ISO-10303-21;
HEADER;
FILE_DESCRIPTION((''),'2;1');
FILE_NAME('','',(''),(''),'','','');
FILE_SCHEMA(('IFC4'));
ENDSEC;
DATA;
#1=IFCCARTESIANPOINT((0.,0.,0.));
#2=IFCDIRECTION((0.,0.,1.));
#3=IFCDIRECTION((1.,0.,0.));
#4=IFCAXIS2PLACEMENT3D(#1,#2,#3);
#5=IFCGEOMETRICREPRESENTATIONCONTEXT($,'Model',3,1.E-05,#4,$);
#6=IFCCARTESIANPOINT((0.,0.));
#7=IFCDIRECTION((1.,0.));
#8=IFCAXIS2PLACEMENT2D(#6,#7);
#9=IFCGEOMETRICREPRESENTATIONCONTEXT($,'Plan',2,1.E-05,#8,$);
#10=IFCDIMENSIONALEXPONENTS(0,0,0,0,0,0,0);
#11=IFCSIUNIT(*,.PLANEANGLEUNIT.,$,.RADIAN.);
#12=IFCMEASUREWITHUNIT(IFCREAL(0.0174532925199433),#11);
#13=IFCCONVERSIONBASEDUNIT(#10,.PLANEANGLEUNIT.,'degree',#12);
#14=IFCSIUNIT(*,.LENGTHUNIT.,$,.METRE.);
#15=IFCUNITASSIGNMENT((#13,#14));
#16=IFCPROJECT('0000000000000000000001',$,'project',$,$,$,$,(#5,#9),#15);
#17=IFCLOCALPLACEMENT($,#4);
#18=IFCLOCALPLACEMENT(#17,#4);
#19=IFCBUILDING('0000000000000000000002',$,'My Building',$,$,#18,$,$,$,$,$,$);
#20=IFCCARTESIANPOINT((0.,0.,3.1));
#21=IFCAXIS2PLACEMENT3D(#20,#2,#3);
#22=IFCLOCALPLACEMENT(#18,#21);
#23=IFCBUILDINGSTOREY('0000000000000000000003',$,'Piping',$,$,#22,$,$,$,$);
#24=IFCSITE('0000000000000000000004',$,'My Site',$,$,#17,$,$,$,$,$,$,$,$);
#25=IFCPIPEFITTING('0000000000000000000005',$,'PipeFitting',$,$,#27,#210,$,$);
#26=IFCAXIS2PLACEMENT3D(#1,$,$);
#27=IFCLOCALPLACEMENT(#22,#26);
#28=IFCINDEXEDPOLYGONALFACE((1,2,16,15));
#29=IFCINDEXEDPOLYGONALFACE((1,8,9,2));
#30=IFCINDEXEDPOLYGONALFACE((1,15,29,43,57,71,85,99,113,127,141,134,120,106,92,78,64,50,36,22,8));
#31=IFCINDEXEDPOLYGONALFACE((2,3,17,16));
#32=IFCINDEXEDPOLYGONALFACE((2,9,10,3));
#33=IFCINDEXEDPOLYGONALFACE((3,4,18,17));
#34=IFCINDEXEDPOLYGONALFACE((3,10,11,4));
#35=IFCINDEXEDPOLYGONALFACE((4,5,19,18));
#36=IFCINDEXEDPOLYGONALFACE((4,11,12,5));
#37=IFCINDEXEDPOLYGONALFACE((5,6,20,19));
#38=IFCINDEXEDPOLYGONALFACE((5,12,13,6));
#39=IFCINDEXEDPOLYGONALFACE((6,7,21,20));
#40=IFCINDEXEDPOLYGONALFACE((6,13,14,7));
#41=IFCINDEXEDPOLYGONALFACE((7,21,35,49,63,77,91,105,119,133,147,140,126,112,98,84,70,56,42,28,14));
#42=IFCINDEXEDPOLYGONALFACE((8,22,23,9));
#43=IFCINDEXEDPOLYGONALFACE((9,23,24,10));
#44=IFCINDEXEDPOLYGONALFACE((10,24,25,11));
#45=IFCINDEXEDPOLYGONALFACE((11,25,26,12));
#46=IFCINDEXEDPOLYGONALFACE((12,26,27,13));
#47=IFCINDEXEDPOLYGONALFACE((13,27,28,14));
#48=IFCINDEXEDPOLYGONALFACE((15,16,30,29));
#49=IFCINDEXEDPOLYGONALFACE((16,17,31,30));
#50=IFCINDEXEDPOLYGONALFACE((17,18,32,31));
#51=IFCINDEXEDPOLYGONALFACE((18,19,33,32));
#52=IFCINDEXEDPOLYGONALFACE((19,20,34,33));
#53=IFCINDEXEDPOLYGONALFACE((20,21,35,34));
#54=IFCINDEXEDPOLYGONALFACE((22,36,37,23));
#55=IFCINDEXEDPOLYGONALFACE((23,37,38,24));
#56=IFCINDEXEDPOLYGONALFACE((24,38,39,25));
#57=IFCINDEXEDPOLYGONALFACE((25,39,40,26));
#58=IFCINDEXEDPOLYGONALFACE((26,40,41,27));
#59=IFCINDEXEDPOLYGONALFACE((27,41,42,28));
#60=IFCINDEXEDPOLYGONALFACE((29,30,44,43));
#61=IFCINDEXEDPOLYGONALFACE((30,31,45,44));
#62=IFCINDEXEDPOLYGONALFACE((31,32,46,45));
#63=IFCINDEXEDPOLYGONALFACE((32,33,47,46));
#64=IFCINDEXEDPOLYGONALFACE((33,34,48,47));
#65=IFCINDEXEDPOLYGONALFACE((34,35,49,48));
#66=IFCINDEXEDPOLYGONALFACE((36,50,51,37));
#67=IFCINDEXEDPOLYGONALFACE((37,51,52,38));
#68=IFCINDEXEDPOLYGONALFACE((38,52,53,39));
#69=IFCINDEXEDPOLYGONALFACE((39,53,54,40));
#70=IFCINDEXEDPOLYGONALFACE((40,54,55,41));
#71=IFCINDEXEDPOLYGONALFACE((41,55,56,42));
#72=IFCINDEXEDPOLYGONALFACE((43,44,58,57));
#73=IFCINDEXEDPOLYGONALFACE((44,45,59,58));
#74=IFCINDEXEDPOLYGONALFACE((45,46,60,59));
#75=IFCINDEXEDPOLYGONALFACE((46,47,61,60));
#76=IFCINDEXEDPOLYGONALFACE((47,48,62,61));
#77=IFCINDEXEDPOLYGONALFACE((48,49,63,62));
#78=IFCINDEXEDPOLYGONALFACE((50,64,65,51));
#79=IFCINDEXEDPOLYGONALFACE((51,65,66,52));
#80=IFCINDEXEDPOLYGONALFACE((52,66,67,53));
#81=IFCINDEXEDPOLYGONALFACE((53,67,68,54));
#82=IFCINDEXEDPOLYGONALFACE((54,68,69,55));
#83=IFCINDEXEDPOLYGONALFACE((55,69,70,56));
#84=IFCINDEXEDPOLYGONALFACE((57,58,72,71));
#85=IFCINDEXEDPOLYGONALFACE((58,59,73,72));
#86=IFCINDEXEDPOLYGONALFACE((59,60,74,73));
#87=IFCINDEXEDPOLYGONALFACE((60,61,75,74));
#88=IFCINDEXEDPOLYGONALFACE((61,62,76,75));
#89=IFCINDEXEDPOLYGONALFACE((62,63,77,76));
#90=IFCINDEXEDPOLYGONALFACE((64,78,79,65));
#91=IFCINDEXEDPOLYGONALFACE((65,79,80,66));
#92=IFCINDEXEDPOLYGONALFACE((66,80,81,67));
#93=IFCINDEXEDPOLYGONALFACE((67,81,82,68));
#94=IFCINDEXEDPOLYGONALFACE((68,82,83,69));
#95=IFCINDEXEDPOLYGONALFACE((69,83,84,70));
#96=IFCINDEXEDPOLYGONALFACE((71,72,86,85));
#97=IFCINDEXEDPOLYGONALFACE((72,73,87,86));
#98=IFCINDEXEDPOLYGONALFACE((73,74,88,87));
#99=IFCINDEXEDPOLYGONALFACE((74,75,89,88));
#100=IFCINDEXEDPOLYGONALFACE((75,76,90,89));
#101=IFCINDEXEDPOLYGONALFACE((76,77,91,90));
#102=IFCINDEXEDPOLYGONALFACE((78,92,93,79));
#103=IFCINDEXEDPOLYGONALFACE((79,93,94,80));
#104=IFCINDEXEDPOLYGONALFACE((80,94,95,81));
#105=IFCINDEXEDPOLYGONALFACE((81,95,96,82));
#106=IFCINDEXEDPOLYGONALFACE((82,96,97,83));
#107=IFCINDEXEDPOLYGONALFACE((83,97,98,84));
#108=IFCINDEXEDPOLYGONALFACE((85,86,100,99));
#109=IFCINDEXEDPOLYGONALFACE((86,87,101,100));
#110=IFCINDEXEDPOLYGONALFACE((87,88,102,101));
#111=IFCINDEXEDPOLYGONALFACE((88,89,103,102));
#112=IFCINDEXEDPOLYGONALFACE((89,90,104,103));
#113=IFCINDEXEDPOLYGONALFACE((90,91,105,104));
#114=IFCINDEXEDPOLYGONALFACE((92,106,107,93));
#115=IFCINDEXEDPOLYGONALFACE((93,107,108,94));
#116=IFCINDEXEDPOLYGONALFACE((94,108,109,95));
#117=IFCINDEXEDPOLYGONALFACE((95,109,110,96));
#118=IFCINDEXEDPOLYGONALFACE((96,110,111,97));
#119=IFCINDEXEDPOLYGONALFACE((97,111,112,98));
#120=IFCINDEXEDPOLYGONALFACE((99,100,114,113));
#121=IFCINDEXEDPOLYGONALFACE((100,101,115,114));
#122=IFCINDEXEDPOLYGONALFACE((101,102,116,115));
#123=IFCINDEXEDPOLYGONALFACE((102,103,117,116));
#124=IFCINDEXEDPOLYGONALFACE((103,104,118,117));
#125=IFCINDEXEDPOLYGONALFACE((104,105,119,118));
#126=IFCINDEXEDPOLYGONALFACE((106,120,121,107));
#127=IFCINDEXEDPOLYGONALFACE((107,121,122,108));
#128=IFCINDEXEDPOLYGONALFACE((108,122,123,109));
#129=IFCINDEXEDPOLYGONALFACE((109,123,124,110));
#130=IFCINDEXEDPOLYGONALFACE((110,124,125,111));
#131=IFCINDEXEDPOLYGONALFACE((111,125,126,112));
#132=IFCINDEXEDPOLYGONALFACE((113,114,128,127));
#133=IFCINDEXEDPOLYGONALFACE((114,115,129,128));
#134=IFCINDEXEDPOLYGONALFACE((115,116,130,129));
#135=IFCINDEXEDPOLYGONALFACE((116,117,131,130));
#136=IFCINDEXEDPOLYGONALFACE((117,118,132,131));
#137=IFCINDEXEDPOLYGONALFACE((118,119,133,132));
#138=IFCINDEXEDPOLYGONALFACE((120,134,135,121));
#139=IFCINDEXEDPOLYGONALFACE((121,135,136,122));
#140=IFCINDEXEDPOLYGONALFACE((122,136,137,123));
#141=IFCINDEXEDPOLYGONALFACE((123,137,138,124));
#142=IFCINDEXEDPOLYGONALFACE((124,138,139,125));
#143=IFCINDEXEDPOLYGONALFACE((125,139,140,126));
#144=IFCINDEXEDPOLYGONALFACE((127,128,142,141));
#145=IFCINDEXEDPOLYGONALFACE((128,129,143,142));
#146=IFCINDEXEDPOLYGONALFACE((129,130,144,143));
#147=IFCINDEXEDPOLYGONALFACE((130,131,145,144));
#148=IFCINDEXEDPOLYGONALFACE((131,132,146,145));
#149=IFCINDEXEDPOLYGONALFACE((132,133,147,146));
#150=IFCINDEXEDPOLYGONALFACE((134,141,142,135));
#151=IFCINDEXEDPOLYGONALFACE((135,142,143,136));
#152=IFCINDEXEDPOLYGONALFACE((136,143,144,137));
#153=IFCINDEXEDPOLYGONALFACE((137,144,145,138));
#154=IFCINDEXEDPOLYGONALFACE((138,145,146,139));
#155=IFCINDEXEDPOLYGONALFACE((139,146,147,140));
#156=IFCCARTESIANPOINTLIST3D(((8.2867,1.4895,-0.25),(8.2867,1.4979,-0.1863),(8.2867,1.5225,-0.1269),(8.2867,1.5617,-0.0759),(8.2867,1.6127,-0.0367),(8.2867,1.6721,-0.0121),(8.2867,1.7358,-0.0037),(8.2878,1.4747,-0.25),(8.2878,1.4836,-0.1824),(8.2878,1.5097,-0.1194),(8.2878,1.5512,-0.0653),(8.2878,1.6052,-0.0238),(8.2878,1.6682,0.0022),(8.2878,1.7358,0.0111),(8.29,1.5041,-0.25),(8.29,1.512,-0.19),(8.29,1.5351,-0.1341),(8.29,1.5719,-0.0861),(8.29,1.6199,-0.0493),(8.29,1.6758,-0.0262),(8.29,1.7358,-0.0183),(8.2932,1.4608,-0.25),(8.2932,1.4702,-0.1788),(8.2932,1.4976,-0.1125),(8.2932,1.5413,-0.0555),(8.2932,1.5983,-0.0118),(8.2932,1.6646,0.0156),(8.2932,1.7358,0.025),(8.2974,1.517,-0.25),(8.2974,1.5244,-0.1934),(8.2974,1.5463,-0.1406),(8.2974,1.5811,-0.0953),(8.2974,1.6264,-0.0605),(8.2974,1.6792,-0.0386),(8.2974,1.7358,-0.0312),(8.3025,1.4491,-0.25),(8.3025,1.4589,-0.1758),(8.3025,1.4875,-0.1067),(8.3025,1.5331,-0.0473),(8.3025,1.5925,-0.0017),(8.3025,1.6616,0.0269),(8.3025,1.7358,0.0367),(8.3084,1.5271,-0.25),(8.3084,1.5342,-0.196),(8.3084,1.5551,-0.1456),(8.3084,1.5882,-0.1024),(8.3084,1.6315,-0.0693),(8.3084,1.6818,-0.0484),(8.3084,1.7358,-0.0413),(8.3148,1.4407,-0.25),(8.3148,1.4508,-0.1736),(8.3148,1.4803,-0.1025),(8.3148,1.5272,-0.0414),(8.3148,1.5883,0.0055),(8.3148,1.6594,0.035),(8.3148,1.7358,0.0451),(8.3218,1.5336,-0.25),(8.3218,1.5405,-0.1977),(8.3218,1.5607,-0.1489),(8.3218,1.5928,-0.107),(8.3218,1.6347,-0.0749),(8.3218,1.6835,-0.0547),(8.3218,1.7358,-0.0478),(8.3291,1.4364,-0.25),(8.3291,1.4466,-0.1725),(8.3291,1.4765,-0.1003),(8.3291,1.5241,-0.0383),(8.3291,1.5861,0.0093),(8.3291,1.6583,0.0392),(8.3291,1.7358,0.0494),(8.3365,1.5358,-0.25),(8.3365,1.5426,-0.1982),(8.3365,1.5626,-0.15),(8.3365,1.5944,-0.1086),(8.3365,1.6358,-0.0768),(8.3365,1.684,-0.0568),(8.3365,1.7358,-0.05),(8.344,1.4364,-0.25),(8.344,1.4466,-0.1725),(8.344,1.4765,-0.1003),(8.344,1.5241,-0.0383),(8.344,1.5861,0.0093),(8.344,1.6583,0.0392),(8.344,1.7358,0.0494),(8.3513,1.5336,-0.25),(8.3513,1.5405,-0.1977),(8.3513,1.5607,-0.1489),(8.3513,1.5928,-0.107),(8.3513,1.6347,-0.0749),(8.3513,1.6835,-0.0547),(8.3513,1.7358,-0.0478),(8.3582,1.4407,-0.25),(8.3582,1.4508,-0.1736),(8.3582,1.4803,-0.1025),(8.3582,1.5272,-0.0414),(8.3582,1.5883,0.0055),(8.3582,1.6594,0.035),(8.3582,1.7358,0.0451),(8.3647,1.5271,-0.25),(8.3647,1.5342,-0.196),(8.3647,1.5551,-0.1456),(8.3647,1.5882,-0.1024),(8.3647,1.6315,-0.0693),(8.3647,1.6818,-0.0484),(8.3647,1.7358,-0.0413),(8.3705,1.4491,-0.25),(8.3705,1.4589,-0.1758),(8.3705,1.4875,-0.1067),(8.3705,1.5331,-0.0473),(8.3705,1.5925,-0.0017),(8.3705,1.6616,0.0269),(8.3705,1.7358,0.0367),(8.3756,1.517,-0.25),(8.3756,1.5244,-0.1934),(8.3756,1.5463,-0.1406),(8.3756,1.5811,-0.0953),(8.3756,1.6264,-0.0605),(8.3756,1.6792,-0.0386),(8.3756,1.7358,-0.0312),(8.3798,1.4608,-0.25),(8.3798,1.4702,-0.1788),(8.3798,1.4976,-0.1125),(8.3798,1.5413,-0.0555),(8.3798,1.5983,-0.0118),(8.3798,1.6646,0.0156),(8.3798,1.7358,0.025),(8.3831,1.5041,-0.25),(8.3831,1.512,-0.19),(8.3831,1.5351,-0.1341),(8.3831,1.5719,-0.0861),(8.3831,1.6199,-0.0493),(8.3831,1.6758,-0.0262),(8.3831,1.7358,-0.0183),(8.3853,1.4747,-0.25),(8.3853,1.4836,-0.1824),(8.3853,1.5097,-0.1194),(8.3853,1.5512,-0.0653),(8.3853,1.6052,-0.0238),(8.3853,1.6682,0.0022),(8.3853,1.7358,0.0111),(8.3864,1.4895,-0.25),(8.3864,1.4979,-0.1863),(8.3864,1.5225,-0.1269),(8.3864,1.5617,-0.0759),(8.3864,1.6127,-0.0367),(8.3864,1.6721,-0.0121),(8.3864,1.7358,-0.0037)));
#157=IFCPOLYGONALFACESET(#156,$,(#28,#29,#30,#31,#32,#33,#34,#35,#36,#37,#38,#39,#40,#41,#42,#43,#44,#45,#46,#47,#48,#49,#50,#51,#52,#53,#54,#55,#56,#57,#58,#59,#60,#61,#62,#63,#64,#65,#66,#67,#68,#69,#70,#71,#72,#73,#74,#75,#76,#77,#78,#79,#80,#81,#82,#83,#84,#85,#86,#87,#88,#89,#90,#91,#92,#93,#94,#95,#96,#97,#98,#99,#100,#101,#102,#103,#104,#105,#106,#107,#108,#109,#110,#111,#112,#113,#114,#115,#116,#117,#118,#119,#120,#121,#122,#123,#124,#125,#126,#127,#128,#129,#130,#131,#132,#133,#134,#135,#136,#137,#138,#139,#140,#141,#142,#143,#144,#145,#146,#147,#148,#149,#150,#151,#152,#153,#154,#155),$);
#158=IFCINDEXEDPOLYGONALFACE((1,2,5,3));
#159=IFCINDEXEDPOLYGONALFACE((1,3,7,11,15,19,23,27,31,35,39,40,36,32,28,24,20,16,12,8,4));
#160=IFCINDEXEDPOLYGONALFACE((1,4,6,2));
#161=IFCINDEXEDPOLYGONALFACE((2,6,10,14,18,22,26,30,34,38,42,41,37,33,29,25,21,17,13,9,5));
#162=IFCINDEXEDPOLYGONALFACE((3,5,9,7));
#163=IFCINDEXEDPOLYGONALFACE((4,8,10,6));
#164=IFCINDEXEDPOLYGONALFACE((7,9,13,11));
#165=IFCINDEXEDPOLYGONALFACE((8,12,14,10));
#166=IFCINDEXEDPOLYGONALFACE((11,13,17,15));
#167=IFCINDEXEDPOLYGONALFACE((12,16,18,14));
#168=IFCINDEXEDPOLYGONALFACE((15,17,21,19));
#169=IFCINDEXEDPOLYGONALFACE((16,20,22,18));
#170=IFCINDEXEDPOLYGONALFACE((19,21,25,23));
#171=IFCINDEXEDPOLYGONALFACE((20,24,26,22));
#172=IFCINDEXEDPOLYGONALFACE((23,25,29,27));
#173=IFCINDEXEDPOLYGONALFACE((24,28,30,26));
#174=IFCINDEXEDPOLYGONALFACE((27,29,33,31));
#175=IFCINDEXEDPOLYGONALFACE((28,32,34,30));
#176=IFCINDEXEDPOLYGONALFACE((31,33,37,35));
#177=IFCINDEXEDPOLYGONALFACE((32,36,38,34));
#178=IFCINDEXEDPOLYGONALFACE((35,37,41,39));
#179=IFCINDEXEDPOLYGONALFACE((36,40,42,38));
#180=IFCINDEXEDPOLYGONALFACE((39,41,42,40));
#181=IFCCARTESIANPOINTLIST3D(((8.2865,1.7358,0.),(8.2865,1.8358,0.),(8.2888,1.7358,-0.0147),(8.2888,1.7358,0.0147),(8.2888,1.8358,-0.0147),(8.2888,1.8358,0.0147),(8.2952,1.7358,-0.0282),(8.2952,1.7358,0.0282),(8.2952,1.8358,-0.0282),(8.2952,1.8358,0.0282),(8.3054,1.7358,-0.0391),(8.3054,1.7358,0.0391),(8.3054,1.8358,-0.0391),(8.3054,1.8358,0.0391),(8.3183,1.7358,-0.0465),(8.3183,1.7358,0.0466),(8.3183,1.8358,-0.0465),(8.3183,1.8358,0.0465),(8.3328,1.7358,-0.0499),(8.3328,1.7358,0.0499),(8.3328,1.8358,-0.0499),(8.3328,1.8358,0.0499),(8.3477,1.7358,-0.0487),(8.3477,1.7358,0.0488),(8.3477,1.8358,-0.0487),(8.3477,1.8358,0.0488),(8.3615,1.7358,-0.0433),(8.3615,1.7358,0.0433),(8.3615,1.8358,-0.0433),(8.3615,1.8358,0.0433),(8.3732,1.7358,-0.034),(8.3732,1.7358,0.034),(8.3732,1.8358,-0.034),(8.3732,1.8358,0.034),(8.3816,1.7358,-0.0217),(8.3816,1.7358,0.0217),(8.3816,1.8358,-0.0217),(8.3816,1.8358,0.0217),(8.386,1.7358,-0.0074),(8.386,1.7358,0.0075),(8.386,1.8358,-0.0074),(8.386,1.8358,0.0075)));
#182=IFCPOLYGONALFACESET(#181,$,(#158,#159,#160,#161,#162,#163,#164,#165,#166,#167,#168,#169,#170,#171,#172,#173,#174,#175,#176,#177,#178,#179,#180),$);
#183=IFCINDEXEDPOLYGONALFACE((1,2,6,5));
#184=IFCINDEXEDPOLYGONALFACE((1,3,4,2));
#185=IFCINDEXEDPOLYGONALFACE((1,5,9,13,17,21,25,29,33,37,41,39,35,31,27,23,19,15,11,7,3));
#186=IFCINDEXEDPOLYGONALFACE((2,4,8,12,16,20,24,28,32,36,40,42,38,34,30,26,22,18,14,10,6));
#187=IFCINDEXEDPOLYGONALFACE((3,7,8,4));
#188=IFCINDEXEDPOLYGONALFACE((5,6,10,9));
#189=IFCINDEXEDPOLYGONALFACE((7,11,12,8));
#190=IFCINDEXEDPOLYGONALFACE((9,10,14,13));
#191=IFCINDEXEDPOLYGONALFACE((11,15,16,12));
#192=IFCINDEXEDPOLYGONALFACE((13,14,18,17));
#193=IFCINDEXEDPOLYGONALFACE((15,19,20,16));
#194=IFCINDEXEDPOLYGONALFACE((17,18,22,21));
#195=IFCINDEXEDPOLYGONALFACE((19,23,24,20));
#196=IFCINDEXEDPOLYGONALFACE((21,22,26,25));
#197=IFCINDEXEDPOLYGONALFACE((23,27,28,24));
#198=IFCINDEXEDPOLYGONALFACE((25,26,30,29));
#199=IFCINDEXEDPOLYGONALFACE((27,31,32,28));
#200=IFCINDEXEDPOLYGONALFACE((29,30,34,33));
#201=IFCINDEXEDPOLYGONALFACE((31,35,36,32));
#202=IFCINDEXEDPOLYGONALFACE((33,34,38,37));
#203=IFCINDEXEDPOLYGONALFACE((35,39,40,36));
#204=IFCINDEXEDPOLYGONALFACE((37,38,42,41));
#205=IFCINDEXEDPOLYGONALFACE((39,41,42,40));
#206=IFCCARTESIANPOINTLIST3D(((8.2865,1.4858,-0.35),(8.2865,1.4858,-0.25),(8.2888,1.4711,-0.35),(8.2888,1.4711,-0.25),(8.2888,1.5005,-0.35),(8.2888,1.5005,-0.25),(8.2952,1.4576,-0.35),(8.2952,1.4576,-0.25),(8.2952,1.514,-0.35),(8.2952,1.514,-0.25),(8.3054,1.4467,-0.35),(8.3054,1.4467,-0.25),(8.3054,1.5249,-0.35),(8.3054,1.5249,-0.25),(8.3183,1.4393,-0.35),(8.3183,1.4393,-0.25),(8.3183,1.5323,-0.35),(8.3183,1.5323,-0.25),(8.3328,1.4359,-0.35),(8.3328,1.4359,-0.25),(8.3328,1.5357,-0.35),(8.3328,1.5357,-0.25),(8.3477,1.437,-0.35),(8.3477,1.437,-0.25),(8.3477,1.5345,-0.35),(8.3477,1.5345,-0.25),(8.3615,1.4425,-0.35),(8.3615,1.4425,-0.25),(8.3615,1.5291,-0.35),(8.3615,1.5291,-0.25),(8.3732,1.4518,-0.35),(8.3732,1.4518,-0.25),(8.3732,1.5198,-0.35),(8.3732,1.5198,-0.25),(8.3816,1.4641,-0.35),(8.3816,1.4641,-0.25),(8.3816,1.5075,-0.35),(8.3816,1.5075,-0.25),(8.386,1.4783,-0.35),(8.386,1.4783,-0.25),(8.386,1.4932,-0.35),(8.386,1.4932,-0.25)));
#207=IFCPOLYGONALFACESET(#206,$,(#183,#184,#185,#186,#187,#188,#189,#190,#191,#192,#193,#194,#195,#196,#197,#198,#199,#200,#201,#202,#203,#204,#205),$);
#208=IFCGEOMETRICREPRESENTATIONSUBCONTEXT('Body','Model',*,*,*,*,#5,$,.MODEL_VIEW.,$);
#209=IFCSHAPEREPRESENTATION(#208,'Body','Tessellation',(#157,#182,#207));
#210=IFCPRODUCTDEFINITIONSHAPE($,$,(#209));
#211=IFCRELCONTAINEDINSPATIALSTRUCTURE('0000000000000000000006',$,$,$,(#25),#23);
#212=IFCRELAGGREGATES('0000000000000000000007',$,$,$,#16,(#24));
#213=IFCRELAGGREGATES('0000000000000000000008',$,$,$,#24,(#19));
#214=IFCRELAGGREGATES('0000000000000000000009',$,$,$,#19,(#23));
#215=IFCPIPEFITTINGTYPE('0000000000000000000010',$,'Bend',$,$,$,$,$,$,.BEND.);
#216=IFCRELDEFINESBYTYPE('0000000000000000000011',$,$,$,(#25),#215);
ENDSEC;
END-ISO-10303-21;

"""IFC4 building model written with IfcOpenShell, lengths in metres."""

from ifc_helpers import new_model, entity, si_unit, converted_unit, frame, origin_with_axes, origin_2d_with_axis, place, context, subcontext, project, spatial, circle, extrude, source, transform, mapped, type_object, type_shapes, element, save


model = new_model("IFC4")

# Units and contexts
model_context = context("Model", 3, precision=1e-05, world=origin_with_axes())
plan_context = context("Plan", 2, precision=1e-05, world=origin_2d_with_axis())
body_context = subcontext(model_context, "Body", "Model", "MODEL_VIEW")
ifc_project = project(units=[converted_unit("PLANEANGLEUNIT", "degree", entity("IfcReal", 0.0174532925199433), si_unit("PLANEANGLEUNIT", "RADIAN"), dimensions=[0, 0, 0, 0, 0, 0, 0]), si_unit("LENGTHUNIT", "METRE")], contexts=[model_context, plan_context])

# Site, building, storey
site_placement = place(None, origin_with_axes())
site = spatial("IfcSite", under=ifc_project, at=site_placement, Name="My Site")
building_placement = place(site_placement, origin_with_axes())
building = spatial("IfcBuilding", under=site, at=building_placement, Name="My Building")
storey_placement = place(building_placement, frame((0.0, 0.0, 3.1), z_axis=(0.0, 0.0, 1.0), x_axis=(1.0, 0.0, 0.0)))
storey = spatial("IfcBuildingStorey", under=building, at=storey_placement, Name="Piping")

# Pipe fitting
pipe_fitting_type_1 = type_object("IfcPipeFittingType", Name="Bend", PredefinedType="BEND")
shared_shape_1 = source(origin_with_axes(), body_context, "Body", "SolidModel", [
    entity("IfcSweptDiskSolid", entity("IfcIndexedPolyCurve", entity("IfcCartesianPointList3D", [[0.0, 0.0, -0.1], [0.0, -0.0732, -0.2768], [0.0, -0.25, -0.35]]), [entity("IfcArcIndex", [1, 2, 3])]), 0.05),
    extrude(circle(Radius=0.05), origin_with_axes(), (0.0, 0.0, -1.0), 0.1),
    extrude(circle(Radius=0.05), frame((0.0, -0.25, -0.35), z_axis=(0.0, -1.0, 0.000022), x_axis=(1.0, 0.0, 0.0)), (0.0, 0.0, 1.0), 0.1),
])
type_shapes(pipe_fitting_type_1, [shared_shape_1])
for number, where, z_axis, x_axis, name in (
    (1, (8.3365, 1.8358, 0.0), (0.0, 1.0, -0.000022), (-1.0, 0.0, 0.0), "PipeFitting"),
):
    element("IfcPipeFitting", number, at=place(storey_placement, frame(where, z_axis=z_axis, x_axis=x_axis)), inside=storey, type_object=pipe_fitting_type_1, Name=name, context=body_context, shape_type="MappedRepresentation", body=[
        mapped(shared_shape_1, transform((0.0, 0.0, 0.0), x_axis=(1.0, 0.0, 0.0), y_axis=(0.0, 1.0, 0.0), z_axis=(0.0, 0.0, 1.0), scale=1.0)),
    ])

save(model, "model.ifc")
